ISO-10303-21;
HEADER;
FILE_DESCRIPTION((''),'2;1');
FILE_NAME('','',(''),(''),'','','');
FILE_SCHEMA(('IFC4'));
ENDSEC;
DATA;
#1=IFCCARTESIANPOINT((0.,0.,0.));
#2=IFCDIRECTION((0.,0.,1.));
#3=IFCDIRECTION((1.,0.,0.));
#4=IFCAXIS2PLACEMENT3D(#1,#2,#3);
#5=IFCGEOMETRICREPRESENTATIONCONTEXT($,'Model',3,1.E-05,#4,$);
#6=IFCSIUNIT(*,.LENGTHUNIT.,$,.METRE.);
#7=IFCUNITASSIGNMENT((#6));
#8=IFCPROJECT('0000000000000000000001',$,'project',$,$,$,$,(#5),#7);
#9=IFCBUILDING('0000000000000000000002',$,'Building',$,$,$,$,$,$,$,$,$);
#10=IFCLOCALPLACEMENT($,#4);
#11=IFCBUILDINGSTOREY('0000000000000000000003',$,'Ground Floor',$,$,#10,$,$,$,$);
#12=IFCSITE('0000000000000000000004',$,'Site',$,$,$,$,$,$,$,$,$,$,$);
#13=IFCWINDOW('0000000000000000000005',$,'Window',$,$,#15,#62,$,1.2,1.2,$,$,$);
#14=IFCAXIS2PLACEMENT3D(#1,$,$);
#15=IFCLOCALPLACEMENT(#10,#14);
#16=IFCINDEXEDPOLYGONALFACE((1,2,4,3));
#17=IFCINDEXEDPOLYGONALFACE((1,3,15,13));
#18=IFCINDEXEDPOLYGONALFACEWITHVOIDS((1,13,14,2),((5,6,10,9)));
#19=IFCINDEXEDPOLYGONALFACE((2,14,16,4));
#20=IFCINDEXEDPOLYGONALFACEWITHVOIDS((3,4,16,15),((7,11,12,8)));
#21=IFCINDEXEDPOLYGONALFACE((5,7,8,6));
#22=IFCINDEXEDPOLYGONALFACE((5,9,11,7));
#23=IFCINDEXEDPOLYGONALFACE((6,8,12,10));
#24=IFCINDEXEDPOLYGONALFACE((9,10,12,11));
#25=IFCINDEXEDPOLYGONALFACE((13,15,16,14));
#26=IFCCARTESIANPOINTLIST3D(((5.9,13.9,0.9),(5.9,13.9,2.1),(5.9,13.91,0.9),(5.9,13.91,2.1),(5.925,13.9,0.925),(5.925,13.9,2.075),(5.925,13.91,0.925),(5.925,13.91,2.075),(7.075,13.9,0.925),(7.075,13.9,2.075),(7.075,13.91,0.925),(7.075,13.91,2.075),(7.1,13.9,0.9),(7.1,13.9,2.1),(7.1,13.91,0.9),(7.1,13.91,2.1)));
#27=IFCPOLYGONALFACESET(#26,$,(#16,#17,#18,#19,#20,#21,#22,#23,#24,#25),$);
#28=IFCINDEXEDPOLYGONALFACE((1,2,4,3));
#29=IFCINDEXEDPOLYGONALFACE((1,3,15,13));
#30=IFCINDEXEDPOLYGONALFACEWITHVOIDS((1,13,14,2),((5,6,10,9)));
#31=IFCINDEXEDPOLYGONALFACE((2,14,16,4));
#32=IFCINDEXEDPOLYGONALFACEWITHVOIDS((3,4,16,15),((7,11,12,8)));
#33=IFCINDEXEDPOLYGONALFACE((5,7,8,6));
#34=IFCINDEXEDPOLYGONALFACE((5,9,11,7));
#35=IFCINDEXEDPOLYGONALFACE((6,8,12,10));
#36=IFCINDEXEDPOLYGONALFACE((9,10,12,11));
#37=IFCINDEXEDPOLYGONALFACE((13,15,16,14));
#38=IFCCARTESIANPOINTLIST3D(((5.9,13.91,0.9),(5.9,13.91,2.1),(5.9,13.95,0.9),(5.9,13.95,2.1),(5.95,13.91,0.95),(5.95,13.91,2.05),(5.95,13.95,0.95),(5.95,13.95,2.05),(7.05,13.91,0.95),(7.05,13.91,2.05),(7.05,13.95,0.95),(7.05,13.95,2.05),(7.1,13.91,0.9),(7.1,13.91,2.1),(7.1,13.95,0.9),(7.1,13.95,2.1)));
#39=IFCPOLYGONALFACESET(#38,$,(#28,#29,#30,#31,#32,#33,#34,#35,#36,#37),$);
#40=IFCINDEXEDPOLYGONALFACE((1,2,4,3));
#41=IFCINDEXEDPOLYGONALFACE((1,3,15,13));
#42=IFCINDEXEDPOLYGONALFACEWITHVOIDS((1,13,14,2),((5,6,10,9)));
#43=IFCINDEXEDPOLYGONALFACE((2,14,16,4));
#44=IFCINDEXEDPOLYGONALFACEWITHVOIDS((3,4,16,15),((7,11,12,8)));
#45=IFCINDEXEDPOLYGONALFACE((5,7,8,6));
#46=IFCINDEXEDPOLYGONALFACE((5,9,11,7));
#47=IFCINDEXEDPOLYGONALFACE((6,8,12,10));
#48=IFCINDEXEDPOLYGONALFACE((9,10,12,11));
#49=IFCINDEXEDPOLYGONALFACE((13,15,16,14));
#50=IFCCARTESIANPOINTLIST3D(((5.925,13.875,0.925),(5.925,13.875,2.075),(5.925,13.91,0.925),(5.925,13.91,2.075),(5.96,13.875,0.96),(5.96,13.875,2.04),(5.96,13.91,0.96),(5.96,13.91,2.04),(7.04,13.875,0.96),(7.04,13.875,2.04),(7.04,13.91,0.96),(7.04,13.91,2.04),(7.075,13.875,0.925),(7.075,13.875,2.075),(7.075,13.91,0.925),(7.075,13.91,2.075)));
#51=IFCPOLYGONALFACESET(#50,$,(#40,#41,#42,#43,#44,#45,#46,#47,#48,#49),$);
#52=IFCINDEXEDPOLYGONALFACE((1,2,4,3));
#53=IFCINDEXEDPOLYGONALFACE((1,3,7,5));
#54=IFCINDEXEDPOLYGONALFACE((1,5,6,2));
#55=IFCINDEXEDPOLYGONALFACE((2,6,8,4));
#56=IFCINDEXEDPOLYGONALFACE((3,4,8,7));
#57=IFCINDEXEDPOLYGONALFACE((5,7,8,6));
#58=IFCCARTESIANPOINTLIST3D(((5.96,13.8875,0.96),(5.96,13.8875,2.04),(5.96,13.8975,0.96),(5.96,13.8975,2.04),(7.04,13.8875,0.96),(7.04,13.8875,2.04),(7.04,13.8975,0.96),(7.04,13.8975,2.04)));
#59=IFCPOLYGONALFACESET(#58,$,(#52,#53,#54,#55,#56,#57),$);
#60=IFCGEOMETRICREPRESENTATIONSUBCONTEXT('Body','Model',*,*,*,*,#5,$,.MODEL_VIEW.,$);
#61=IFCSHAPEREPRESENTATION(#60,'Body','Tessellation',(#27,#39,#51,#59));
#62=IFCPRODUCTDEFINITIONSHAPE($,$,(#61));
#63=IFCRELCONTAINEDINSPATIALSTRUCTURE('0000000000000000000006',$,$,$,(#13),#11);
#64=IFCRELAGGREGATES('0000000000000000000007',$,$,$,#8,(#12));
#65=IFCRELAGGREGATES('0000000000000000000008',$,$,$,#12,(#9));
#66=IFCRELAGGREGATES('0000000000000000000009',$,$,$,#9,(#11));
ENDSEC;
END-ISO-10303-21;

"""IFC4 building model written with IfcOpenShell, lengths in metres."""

from ifc_helpers import new_model, si_unit, frame, origin_with_axes, place, context, subcontext, project, spatial, line, indexed_curve, outline, extrude, element, save


model = new_model("IFC4")

# Units and contexts
model_context = context("Model", 3, precision=1e-05, world=origin_with_axes())
body_context = subcontext(model_context, "Body", "Model", "MODEL_VIEW")
ifc_project = project(units=[si_unit("LENGTHUNIT", "METRE")], contexts=[model_context])

# Site, building, storey
site = spatial("IfcSite", under=ifc_project, Name="Site")
building = spatial("IfcBuilding", under=site, Name="Building")
storey_placement = place(None, origin_with_axes())
storey = spatial("IfcBuildingStorey", under=building, at=storey_placement, Name="Ground Floor")

# Window
window_1_placement = place(storey_placement, frame((7.1, 14.0, 0.9), z_axis=(0.0, 0.0, 1.0), x_axis=(-1.0, 0.0, 0.0)))
element("IfcWindow", 1, at=window_1_placement, inside=storey, Name="Window", OverallHeight=1.2, OverallWidth=1.2, context=body_context, shape_type="SweptSolid", body=[
    extrude(outline(indexed_curve([(0.0, 0.0), (1.2, 0.0), (1.2, 1.2), (0.0, 1.2)], segments=[line(1, 2, 3, 4, 1)]), holes=[indexed_curve([(0.025, 0.025), (1.175, 0.025), (1.175, 1.175), (0.025, 1.175)], segments=[line(1, 2, 3, 4, 1)])]), frame((0.0, 0.09, 0.0), z_axis=(0.0, -1.0, 0.0), x_axis=(1.0, 0.0, 0.0)), (0.0, 0.0, -1.0), 0.01),
    extrude(outline(indexed_curve([(0.0, 0.0), (1.2, 0.0), (1.2, 1.2), (0.0, 1.2)], segments=[line(1, 2, 3, 4, 1)]), holes=[indexed_curve([(0.05, 0.05), (1.15, 0.05), (1.15, 1.15), (0.05, 1.15)], segments=[line(1, 2, 3, 4, 1)])]), frame((0.0, 0.05, 0.0), z_axis=(0.0, -1.0, 0.0), x_axis=(1.0, 0.0, 0.0)), (0.0, 0.0, -1.0), 0.04),
    extrude(outline(indexed_curve([(0.0, 0.0), (1.15, 0.0), (1.15, 1.15), (0.0, 1.15)], segments=[line(1, 2, 3, 4, 1)]), holes=[indexed_curve([(0.035, 0.035), (1.115, 0.035), (1.115, 1.115), (0.035, 1.115)], segments=[line(1, 2, 3, 4, 1)])]), frame((0.025, 0.09, 0.025), z_axis=(0.0, -1.0, 0.0), x_axis=(1.0, 0.0, 0.0)), (0.0, 0.0, -1.0), 0.035),
    extrude(outline(indexed_curve([(0.035, 0.035), (1.115, 0.035), (1.115, 1.115), (0.035, 1.115)], segments=[line(1, 2, 3, 4, 1)])), frame((0.025, 0.1025, 0.025), z_axis=(0.0, -1.0, 0.0), x_axis=(1.0, 0.0, 0.0)), (0.0, 0.0, -1.0), 0.01),
])

save(model, "model.ifc")
